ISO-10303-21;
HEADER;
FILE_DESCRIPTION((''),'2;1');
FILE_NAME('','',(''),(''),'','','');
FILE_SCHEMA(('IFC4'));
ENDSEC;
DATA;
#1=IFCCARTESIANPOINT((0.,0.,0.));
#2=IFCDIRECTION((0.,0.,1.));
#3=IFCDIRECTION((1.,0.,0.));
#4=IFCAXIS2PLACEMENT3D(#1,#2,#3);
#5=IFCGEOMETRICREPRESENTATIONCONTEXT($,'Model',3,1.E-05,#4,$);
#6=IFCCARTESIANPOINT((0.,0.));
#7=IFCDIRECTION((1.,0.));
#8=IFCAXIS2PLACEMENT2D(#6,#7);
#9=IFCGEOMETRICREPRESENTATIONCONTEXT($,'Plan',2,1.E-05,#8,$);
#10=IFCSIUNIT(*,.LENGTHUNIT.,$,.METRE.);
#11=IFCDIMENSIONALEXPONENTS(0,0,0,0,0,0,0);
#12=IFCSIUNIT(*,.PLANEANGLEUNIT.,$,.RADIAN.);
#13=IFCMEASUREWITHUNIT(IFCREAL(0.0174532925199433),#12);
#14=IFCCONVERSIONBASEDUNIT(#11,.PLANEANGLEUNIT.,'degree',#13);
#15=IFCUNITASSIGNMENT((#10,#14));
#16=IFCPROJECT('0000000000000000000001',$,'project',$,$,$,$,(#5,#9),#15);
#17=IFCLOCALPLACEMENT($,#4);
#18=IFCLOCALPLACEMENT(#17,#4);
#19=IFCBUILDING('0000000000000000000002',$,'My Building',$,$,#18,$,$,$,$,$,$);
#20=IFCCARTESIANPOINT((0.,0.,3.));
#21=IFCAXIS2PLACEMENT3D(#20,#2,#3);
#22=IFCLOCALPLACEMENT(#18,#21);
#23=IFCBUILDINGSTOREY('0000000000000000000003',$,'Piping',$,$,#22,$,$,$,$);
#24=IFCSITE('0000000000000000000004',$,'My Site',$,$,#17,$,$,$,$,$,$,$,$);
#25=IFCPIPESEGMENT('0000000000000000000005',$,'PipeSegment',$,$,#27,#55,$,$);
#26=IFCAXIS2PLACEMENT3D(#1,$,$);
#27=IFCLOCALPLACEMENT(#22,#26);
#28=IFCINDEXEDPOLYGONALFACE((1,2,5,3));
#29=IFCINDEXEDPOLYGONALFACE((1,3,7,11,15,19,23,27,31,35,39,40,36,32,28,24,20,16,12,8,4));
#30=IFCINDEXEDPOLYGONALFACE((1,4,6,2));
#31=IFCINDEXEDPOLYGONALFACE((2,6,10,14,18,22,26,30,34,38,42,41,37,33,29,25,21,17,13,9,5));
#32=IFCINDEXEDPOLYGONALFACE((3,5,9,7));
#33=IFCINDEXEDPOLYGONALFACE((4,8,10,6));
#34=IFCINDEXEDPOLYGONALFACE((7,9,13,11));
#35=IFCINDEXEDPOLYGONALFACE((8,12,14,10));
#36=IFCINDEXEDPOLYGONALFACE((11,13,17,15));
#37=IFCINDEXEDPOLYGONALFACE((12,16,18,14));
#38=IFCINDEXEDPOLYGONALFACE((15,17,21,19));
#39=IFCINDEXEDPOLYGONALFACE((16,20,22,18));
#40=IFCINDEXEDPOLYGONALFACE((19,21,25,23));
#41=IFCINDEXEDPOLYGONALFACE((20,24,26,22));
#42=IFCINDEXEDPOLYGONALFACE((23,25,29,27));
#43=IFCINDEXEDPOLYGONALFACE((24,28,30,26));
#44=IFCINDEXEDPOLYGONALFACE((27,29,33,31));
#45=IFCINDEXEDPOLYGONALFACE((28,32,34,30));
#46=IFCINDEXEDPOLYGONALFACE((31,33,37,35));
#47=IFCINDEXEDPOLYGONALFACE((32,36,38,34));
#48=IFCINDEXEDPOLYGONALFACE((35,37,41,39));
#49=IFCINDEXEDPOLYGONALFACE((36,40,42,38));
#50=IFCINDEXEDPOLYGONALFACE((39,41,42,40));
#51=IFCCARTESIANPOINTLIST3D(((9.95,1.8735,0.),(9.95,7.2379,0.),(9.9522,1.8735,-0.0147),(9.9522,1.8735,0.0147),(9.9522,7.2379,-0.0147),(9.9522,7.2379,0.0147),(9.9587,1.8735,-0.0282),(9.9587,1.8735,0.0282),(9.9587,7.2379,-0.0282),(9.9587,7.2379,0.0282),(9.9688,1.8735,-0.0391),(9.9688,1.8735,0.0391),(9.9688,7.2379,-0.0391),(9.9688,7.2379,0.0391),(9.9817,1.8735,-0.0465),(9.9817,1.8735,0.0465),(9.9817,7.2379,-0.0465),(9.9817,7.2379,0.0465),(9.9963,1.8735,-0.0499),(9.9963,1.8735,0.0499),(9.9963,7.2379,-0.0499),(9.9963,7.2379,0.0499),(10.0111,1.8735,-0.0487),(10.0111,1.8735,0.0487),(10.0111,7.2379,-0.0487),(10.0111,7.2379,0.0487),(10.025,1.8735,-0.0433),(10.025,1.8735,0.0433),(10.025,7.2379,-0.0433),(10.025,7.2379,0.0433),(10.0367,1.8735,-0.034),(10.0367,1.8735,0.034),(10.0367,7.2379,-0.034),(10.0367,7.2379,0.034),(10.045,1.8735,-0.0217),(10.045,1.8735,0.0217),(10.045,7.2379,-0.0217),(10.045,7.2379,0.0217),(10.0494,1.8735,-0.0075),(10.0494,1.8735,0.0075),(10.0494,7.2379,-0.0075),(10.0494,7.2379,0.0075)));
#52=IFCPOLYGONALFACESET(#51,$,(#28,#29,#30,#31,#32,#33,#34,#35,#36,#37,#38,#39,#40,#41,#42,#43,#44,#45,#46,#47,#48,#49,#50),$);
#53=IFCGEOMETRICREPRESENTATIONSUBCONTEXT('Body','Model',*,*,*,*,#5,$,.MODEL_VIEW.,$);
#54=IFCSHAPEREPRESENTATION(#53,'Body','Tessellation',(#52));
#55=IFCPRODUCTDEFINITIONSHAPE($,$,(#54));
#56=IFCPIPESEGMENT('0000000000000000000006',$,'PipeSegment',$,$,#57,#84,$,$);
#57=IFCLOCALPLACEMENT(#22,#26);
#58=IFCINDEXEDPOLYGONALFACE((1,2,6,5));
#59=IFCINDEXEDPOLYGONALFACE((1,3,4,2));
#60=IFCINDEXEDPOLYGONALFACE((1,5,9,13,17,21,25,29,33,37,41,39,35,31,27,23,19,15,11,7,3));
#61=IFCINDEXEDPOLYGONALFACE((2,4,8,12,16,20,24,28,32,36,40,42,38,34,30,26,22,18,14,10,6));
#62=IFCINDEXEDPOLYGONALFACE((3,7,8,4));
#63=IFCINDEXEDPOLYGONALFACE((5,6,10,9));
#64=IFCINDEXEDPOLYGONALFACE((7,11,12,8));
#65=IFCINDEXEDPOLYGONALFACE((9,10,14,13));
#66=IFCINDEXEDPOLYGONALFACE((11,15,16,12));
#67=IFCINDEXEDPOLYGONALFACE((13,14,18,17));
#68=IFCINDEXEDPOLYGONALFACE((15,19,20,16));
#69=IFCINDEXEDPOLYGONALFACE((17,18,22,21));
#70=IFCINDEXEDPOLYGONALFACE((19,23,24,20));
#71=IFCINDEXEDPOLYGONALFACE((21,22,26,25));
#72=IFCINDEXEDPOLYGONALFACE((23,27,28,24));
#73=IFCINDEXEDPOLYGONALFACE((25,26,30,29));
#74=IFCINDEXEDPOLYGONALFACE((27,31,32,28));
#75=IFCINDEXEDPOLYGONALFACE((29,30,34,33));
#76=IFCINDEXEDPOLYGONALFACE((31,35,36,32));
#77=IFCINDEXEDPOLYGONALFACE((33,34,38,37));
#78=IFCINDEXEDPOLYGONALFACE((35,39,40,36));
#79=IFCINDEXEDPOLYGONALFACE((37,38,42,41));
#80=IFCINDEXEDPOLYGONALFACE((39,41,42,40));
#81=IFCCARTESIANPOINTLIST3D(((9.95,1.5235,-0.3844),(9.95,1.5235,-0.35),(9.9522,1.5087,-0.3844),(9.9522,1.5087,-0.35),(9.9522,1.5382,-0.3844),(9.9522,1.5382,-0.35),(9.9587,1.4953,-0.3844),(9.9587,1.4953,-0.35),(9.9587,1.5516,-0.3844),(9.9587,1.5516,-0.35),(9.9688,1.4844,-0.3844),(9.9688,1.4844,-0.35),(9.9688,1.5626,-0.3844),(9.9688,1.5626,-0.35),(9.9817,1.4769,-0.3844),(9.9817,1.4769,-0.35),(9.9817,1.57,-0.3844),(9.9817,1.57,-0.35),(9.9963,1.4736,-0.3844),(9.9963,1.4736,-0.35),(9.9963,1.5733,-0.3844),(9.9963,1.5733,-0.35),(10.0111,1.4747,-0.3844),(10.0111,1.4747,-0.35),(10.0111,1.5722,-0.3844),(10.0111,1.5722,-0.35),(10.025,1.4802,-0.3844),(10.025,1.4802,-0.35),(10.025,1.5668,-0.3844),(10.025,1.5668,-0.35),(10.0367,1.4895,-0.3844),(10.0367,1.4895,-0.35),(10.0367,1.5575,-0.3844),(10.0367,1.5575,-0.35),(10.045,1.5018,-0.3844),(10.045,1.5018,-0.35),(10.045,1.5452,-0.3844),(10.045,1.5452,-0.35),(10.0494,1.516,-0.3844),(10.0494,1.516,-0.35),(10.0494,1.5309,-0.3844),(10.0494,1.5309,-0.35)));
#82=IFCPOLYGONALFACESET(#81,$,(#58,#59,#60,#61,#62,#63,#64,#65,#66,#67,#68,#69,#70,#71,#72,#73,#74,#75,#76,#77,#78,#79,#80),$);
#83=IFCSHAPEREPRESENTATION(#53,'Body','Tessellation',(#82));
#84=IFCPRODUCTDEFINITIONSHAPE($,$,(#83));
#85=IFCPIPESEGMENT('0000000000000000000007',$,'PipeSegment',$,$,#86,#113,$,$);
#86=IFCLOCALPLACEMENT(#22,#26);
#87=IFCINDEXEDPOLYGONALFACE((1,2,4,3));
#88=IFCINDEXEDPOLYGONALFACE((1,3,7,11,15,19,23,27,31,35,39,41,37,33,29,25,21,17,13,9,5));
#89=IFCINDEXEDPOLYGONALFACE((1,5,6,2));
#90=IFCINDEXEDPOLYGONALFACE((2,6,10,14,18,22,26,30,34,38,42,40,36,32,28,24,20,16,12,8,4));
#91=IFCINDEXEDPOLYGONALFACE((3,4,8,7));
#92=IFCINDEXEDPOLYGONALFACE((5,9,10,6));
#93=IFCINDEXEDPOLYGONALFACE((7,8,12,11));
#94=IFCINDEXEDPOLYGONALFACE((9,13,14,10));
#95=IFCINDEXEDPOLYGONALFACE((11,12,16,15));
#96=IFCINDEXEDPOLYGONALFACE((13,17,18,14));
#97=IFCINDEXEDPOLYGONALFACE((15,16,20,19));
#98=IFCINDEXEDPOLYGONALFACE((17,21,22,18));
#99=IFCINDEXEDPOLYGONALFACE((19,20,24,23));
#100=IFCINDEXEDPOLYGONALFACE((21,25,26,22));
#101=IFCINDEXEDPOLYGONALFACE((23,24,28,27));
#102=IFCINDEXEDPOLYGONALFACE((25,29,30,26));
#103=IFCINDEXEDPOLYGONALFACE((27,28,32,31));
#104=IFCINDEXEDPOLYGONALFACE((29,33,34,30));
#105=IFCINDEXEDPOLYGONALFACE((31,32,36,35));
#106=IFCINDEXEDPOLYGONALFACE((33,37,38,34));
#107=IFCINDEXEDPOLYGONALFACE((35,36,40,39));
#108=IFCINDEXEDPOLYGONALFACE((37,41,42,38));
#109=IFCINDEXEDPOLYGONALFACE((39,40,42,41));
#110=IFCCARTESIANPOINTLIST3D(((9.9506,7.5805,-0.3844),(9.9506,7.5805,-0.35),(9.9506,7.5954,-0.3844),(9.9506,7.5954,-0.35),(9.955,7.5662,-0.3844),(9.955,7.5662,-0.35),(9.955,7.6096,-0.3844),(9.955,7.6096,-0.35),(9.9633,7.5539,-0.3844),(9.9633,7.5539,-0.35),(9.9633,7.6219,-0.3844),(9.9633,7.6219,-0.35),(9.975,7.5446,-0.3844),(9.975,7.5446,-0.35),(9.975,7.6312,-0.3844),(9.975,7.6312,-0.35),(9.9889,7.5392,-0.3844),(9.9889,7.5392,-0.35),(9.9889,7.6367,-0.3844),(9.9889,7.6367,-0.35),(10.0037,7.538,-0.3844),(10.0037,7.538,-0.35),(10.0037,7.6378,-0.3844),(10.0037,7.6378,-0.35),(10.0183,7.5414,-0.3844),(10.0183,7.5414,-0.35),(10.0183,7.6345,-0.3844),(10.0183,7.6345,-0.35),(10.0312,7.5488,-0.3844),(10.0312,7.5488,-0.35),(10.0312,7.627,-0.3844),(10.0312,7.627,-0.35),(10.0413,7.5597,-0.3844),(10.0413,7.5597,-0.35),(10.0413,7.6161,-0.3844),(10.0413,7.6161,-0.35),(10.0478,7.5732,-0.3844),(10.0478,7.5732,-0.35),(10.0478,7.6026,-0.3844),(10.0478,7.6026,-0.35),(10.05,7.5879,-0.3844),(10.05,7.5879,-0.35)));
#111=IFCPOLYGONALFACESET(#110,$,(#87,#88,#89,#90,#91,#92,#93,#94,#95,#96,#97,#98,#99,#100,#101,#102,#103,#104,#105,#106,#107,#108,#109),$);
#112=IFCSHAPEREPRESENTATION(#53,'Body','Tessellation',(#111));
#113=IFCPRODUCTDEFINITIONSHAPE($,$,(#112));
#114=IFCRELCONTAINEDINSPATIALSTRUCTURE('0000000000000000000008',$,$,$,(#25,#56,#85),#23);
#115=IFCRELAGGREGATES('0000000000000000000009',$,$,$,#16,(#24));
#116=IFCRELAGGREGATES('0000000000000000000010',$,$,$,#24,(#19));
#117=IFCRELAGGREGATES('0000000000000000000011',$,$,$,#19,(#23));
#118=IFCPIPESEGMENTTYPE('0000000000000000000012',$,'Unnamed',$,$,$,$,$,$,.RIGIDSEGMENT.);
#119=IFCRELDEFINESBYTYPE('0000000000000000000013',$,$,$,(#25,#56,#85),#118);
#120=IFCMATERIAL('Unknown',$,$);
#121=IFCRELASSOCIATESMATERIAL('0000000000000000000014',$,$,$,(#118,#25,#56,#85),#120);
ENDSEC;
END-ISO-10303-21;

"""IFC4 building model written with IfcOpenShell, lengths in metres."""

from ifc_helpers import new_model, entity, si_unit, converted_unit, frame, origin_with_axes, origin_2d_with_axis, place, context, subcontext, project, spatial, circle, extrude, material, material_profile, profile_set, profile_usage, type_object, element, save


model = new_model("IFC4")

# Units and contexts
model_context = context("Model", 3, precision=1e-05, world=origin_with_axes())
plan_context = context("Plan", 2, precision=1e-05, world=origin_2d_with_axis())
body_context = subcontext(model_context, "Body", "Model", "MODEL_VIEW")
ifc_project = project(units=[si_unit("LENGTHUNIT", "METRE"), converted_unit("PLANEANGLEUNIT", "degree", entity("IfcReal", 0.0174532925199433), si_unit("PLANEANGLEUNIT", "RADIAN"), dimensions=[0, 0, 0, 0, 0, 0, 0])], contexts=[model_context, plan_context])

# Site, building, storey
site_placement = place(None, origin_with_axes())
site = spatial("IfcSite", under=ifc_project, at=site_placement, Name="My Site")
building_placement = place(site_placement, origin_with_axes())
building = spatial("IfcBuilding", under=site, at=building_placement, Name="My Building")
storey_placement = place(building_placement, frame((0.0, 0.0, 3.0), z_axis=(0.0, 0.0, 1.0), x_axis=(1.0, 0.0, 0.0)))
storey = spatial("IfcBuildingStorey", under=building, at=storey_placement, Name="Piping")

# Pipe segments
ifc_material = material(Name="Unknown")
ifc_material_profile = material_profile(ifc_material, circle(Radius=0.05))
ifc_profile_set = profile_set([ifc_material_profile])
pipe_segment_type = type_object("IfcPipeSegmentType", Name="Unnamed", PredefinedType="RIGIDSEGMENT", material=ifc_profile_set)
ifc_profile_usage_1 = profile_usage(ifc_profile_set, cardinal=5)
pipe_segment_1_placement = place(storey_placement, frame((10.0, 1.8735, 0.0), z_axis=(0.0, 1.0, 0.0), x_axis=(-1.0, 0.0, 0.0)))
element("IfcPipeSegment", 1, at=pipe_segment_1_placement, inside=storey, type_object=pipe_segment_type, material=ifc_profile_usage_1, Name="PipeSegment", context=body_context, shape_type="SweptSolid", body=[
    extrude(circle(Radius=0.05), origin_with_axes(), (0.0, 0.0, 1.0), 5.3645),
])
ifc_profile_usage_2 = profile_usage(ifc_profile_set, cardinal=5)
pipe_segment_2_placement = place(storey_placement, frame((10.0, 1.5235, -0.35), z_axis=(0.0, 0.0, -1.0), x_axis=(-1.0, 0.0, 0.0)))
element("IfcPipeSegment", 2, at=pipe_segment_2_placement, inside=storey, type_object=pipe_segment_type, material=ifc_profile_usage_2, Name="PipeSegment", context=body_context, shape_type="SweptSolid", body=[
    extrude(circle(Radius=0.05), origin_with_axes(), (0.0, 0.0, 1.0), 0.0344),
])
ifc_profile_usage_3 = profile_usage(ifc_profile_set, cardinal=5)
pipe_segment_3_placement = place(storey_placement, frame((10.0, 7.5879, -0.35), z_axis=(0.0, 0.0, -1.0), x_axis=(1.0, 0.0, 0.0)))
element("IfcPipeSegment", 3, at=pipe_segment_3_placement, inside=storey, type_object=pipe_segment_type, material=ifc_profile_usage_3, Name="PipeSegment", context=body_context, shape_type="SweptSolid", body=[
    extrude(circle(Radius=0.05), origin_with_axes(), (0.0, 0.0, 1.0), 0.0344),
])

save(model, "model.ifc")
